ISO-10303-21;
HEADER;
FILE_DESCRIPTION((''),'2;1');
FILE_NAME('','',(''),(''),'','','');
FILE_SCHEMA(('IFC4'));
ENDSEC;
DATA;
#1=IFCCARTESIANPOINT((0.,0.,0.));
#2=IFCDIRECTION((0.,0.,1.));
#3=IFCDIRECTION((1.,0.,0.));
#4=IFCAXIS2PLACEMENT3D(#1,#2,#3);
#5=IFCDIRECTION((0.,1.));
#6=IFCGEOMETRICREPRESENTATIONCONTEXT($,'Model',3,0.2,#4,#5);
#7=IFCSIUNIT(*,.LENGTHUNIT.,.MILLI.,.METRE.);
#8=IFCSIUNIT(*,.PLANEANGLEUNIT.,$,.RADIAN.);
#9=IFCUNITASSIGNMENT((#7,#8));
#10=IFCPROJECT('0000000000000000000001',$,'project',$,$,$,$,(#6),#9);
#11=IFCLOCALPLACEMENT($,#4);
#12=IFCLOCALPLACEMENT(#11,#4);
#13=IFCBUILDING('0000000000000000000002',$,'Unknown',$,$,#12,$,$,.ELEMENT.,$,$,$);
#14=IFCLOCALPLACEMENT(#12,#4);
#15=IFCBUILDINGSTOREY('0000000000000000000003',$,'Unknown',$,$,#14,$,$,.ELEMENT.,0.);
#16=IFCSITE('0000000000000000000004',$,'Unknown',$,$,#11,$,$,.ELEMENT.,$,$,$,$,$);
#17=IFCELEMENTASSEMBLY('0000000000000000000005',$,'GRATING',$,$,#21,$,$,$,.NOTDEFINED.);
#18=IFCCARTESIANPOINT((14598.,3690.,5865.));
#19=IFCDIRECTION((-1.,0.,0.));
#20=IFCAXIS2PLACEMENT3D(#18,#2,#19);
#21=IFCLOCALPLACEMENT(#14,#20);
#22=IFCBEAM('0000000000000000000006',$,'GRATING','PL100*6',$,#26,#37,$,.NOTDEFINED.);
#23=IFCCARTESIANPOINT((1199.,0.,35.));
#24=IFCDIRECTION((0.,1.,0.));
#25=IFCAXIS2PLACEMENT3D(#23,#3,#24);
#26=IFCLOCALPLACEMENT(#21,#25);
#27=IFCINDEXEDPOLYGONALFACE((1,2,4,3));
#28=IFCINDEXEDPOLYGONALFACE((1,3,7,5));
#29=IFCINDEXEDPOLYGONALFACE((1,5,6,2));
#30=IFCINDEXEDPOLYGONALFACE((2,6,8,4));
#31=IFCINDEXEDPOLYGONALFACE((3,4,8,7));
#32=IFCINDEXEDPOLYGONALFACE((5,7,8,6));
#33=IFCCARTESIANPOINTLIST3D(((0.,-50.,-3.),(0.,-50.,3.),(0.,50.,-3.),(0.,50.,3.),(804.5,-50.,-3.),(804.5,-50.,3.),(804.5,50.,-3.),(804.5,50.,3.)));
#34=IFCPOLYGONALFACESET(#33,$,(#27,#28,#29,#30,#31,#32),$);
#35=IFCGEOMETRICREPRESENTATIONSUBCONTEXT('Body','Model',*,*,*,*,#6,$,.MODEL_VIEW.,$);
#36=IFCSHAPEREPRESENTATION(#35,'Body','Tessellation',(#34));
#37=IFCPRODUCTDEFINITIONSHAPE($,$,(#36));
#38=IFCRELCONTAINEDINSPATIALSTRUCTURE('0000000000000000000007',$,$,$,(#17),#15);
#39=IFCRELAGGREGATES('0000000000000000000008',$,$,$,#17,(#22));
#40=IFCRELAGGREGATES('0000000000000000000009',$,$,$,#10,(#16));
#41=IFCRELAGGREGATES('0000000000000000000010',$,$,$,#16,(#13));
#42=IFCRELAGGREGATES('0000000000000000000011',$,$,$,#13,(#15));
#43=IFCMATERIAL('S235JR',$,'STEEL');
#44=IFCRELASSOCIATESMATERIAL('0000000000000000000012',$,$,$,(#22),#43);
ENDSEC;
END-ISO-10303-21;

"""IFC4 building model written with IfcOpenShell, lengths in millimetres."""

from ifc_helpers import new_model, si_unit, direction, frame, origin_with_axes, place, context, subcontext, project, spatial, line, indexed_curve, outline, extrude, material, element, aggregate, save


model = new_model("IFC4")

# Units and contexts
model_context = context("Model", 3, precision=0.2, world=origin_with_axes(), true_north=direction((0.0, 1.0)))
body_context = subcontext(model_context, "Body", "Model", "MODEL_VIEW")
ifc_project = project(units=[si_unit("LENGTHUNIT", "METRE", prefix="MILLI"), si_unit("PLANEANGLEUNIT", "RADIAN")], contexts=[model_context])

# Site, building, storey
site_placement = place(None, origin_with_axes())
site = spatial("IfcSite", under=ifc_project, at=site_placement, Name="Unknown", CompositionType="ELEMENT")
building_placement = place(site_placement, origin_with_axes())
building = spatial("IfcBuilding", under=site, at=building_placement, Name="Unknown", CompositionType="ELEMENT")
storey_placement = place(building_placement, origin_with_axes())
storey = spatial("IfcBuildingStorey", under=building, at=storey_placement, Name="Unknown", CompositionType="ELEMENT", Elevation=0.0)

# Element assembly, beam
assembly_1_placement = place(storey_placement, frame((14598.0, 3690.0, 5865.0), z_axis=(0.0, 0.0, 1.0), x_axis=(-1.0, 0.0, 0.0)))
assembly_1 = element("IfcElementAssembly", 1, at=assembly_1_placement, inside=storey, Name="GRATING", PredefinedType="NOTDEFINED")
ifc_material_1 = material(Name="S235JR", Category="STEEL")
beam_1_placement = place(assembly_1_placement, frame((1199.0, 0.0, 35.0), z_axis=(1.0, 0.0, 0.0), x_axis=(0.0, 1.0, 0.0)))
beam_1 = element("IfcBeam", 2, at=beam_1_placement, material=ifc_material_1, Name="GRATING", Description="PL100*6", PredefinedType="NOTDEFINED", context=body_context, shape_type="SolidModel", body=[
    extrude(outline(indexed_curve([(-3.0, -50.0), (3.0, -50.0), (3.0, 50.0), (-3.0, 50.0)], segments=[line(1, 2, 3, 4, 1)])), frame((0.0, 0.0, 0.0), z_axis=(-1.0, 0.0, 0.0), x_axis=(0.0, 0.0, 1.0)), (0.0, -0.000002, -1.0), 804.5),
])
aggregate(assembly_1, [beam_1])

save(model, "model.ifc")
